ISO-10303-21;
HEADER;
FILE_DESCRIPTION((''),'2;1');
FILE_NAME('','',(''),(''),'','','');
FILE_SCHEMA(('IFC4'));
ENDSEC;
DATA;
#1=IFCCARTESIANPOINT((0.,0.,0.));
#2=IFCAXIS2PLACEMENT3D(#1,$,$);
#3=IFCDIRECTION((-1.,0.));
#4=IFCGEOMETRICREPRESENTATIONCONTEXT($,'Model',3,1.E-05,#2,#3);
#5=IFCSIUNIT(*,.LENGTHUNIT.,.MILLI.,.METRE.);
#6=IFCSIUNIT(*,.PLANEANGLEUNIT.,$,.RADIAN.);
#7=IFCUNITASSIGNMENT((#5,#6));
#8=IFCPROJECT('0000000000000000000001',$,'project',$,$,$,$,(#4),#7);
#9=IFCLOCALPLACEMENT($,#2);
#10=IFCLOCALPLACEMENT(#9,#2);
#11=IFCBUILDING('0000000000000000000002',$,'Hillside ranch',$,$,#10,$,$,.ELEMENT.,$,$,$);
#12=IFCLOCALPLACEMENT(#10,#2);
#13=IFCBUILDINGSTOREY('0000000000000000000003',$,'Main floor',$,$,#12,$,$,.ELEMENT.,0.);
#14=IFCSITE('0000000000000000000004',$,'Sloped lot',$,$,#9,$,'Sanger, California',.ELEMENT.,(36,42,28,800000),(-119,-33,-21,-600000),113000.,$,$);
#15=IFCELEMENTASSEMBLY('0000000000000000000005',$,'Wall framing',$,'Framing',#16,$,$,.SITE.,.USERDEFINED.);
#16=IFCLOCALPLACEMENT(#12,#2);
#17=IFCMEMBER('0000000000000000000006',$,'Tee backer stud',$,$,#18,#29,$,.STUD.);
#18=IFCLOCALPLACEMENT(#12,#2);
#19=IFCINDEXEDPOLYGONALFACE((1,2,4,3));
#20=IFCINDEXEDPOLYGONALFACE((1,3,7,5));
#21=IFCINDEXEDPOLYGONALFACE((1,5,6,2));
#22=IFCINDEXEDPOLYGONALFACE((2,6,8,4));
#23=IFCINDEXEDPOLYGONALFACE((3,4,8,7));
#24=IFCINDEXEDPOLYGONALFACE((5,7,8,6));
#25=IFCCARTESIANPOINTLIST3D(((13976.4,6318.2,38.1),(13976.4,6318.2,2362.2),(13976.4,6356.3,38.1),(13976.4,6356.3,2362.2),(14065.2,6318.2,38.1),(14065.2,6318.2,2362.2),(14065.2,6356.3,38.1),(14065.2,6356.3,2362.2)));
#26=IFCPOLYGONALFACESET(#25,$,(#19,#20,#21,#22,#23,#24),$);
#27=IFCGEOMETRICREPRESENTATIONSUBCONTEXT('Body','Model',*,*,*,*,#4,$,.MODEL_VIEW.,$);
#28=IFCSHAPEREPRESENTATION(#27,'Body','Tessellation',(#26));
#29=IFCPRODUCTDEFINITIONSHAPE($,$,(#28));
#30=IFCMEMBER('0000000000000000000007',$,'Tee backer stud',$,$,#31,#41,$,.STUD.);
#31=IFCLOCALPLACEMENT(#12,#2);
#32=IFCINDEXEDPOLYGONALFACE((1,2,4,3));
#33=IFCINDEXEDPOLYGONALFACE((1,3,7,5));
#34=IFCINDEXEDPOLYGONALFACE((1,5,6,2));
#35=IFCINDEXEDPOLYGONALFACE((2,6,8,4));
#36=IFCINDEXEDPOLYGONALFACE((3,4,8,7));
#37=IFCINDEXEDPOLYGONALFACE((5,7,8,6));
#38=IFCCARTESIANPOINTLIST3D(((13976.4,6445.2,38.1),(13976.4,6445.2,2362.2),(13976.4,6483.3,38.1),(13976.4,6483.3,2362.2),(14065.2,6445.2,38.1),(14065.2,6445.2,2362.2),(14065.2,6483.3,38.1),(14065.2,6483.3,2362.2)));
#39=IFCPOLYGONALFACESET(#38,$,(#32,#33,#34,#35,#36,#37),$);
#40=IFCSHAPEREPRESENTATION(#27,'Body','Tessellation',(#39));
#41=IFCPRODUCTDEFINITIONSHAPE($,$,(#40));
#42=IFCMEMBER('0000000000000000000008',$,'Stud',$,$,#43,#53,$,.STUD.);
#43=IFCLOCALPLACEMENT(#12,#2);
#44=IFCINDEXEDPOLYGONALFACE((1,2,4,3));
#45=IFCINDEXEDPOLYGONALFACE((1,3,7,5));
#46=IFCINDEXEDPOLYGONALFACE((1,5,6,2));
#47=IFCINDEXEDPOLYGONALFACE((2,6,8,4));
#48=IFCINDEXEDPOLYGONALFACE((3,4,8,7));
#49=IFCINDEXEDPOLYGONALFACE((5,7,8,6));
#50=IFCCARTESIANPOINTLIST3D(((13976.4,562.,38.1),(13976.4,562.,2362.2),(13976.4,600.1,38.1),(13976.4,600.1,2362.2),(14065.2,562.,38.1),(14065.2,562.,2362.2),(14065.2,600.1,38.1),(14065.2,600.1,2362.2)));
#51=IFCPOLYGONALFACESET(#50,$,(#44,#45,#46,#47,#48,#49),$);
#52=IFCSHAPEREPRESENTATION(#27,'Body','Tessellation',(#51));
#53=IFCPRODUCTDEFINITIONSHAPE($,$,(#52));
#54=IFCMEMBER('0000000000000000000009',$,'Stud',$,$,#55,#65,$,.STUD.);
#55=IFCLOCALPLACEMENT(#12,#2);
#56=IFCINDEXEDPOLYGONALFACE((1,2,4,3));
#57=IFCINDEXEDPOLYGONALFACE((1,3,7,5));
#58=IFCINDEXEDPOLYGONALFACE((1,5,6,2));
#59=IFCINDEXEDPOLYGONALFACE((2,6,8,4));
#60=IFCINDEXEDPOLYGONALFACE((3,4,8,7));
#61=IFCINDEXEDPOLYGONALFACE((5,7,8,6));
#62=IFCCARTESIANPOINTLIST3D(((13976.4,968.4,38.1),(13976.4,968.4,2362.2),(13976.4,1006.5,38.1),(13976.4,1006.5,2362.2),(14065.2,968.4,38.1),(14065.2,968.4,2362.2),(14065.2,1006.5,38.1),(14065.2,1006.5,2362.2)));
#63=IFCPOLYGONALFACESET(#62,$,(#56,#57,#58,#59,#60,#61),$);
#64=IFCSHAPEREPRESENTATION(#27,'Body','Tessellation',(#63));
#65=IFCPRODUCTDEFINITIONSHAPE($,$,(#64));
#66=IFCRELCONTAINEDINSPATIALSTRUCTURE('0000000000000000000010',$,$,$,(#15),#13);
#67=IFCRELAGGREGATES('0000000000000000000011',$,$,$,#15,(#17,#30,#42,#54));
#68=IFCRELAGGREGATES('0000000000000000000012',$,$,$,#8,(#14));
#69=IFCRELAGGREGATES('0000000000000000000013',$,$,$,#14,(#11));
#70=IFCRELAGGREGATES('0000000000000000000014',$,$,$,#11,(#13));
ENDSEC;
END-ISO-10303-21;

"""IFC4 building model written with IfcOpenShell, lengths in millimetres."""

from ifc_helpers import new_model, si_unit, direction, frame, origin, origin_with_axes, place, context, subcontext, project, spatial, polyline, outline, extrude, element, aggregate, save


model = new_model("IFC4")

# Units and contexts
model_context = context("Model", 3, precision=1e-05, world=origin(), true_north=direction((-1.0, 0.0)))
body_context = subcontext(model_context, "Body", "Model", "MODEL_VIEW")
ifc_project = project(units=[si_unit("LENGTHUNIT", "METRE", prefix="MILLI"), si_unit("PLANEANGLEUNIT", "RADIAN")], contexts=[model_context])

# Site, building, storey
site_placement = place(None, origin())
site = spatial("IfcSite", under=ifc_project, at=site_placement, Name="Sloped lot", LongName="Sanger, California", CompositionType="ELEMENT", RefLatitude=(36, 42, 28, 800000), RefLongitude=(-119, -33, -21, -600000), RefElevation=113000.0)
building_placement = place(site_placement, origin())
building = spatial("IfcBuilding", under=site, at=building_placement, Name="Hillside ranch", CompositionType="ELEMENT")
storey_placement = place(building_placement, origin())
storey = spatial("IfcBuildingStorey", under=building, at=storey_placement, Name="Main floor", CompositionType="ELEMENT", Elevation=0.0)

# Element assembly, members
assembly_placement = place(storey_placement, origin_with_axes())
assembly = element("IfcElementAssembly", 1, at=assembly_placement, inside=storey, Name="Wall framing", ObjectType="Framing", AssemblyPlace="SITE", PredefinedType="USERDEFINED")
member_1_placement = place(storey_placement, origin_with_axes())
member_1 = element("IfcMember", 2, at=member_1_placement, Name="Tee backer stud", PredefinedType="STUD", context=body_context, shape_type="SweptSolid", body=[
    extrude(outline(polyline([(0.0, 0.0), (38.1, 0.0), (38.1, 88.9), (0.0, 88.9), (0.0, 0.0)])), frame((14065.2, 6318.2, 38.1), z_axis=(0.0, 0.0, 1.0), x_axis=(0.0, 1.0, 0.0)), (0.0, 0.0, 1.0), 2324.1),
])
member_2_placement = place(storey_placement, origin_with_axes())
member_2 = element("IfcMember", 3, at=member_2_placement, Name="Tee backer stud", PredefinedType="STUD", context=body_context, shape_type="SweptSolid", body=[
    extrude(outline(polyline([(0.0, 0.0), (38.1, 0.0), (38.1, 88.9), (0.0, 88.9), (0.0, 0.0)])), frame((14065.2, 6445.2, 38.1), z_axis=(0.0, 0.0, 1.0), x_axis=(0.0, 1.0, 0.0)), (0.0, 0.0, 1.0), 2324.1),
])
member_3_placement = place(storey_placement, origin_with_axes())
member_3 = element("IfcMember", 4, at=member_3_placement, Name="Stud", PredefinedType="STUD", context=body_context, shape_type="SweptSolid", body=[
    extrude(outline(polyline([(0.0, 0.0), (38.1, 0.0), (38.1, 88.9), (0.0, 88.9), (0.0, 0.0)])), frame((14065.2, 562.0, 38.1), z_axis=(0.0, 0.0, 1.0), x_axis=(0.0, 1.0, 0.0)), (0.0, 0.0, 1.0), 2324.1),
])
member_4_placement = place(storey_placement, origin_with_axes())
member_4 = element("IfcMember", 5, at=member_4_placement, Name="Stud", PredefinedType="STUD", context=body_context, shape_type="SweptSolid", body=[
    extrude(outline(polyline([(0.0, 0.0), (38.1, 0.0), (38.1, 88.9), (0.0, 88.9), (0.0, 0.0)])), frame((14065.2, 968.4, 38.1), z_axis=(0.0, 0.0, 1.0), x_axis=(0.0, 1.0, 0.0)), (0.0, 0.0, 1.0), 2324.1),
])
aggregate(assembly, [member_1, member_2, member_3, member_4])

save(model, "model.ifc")
